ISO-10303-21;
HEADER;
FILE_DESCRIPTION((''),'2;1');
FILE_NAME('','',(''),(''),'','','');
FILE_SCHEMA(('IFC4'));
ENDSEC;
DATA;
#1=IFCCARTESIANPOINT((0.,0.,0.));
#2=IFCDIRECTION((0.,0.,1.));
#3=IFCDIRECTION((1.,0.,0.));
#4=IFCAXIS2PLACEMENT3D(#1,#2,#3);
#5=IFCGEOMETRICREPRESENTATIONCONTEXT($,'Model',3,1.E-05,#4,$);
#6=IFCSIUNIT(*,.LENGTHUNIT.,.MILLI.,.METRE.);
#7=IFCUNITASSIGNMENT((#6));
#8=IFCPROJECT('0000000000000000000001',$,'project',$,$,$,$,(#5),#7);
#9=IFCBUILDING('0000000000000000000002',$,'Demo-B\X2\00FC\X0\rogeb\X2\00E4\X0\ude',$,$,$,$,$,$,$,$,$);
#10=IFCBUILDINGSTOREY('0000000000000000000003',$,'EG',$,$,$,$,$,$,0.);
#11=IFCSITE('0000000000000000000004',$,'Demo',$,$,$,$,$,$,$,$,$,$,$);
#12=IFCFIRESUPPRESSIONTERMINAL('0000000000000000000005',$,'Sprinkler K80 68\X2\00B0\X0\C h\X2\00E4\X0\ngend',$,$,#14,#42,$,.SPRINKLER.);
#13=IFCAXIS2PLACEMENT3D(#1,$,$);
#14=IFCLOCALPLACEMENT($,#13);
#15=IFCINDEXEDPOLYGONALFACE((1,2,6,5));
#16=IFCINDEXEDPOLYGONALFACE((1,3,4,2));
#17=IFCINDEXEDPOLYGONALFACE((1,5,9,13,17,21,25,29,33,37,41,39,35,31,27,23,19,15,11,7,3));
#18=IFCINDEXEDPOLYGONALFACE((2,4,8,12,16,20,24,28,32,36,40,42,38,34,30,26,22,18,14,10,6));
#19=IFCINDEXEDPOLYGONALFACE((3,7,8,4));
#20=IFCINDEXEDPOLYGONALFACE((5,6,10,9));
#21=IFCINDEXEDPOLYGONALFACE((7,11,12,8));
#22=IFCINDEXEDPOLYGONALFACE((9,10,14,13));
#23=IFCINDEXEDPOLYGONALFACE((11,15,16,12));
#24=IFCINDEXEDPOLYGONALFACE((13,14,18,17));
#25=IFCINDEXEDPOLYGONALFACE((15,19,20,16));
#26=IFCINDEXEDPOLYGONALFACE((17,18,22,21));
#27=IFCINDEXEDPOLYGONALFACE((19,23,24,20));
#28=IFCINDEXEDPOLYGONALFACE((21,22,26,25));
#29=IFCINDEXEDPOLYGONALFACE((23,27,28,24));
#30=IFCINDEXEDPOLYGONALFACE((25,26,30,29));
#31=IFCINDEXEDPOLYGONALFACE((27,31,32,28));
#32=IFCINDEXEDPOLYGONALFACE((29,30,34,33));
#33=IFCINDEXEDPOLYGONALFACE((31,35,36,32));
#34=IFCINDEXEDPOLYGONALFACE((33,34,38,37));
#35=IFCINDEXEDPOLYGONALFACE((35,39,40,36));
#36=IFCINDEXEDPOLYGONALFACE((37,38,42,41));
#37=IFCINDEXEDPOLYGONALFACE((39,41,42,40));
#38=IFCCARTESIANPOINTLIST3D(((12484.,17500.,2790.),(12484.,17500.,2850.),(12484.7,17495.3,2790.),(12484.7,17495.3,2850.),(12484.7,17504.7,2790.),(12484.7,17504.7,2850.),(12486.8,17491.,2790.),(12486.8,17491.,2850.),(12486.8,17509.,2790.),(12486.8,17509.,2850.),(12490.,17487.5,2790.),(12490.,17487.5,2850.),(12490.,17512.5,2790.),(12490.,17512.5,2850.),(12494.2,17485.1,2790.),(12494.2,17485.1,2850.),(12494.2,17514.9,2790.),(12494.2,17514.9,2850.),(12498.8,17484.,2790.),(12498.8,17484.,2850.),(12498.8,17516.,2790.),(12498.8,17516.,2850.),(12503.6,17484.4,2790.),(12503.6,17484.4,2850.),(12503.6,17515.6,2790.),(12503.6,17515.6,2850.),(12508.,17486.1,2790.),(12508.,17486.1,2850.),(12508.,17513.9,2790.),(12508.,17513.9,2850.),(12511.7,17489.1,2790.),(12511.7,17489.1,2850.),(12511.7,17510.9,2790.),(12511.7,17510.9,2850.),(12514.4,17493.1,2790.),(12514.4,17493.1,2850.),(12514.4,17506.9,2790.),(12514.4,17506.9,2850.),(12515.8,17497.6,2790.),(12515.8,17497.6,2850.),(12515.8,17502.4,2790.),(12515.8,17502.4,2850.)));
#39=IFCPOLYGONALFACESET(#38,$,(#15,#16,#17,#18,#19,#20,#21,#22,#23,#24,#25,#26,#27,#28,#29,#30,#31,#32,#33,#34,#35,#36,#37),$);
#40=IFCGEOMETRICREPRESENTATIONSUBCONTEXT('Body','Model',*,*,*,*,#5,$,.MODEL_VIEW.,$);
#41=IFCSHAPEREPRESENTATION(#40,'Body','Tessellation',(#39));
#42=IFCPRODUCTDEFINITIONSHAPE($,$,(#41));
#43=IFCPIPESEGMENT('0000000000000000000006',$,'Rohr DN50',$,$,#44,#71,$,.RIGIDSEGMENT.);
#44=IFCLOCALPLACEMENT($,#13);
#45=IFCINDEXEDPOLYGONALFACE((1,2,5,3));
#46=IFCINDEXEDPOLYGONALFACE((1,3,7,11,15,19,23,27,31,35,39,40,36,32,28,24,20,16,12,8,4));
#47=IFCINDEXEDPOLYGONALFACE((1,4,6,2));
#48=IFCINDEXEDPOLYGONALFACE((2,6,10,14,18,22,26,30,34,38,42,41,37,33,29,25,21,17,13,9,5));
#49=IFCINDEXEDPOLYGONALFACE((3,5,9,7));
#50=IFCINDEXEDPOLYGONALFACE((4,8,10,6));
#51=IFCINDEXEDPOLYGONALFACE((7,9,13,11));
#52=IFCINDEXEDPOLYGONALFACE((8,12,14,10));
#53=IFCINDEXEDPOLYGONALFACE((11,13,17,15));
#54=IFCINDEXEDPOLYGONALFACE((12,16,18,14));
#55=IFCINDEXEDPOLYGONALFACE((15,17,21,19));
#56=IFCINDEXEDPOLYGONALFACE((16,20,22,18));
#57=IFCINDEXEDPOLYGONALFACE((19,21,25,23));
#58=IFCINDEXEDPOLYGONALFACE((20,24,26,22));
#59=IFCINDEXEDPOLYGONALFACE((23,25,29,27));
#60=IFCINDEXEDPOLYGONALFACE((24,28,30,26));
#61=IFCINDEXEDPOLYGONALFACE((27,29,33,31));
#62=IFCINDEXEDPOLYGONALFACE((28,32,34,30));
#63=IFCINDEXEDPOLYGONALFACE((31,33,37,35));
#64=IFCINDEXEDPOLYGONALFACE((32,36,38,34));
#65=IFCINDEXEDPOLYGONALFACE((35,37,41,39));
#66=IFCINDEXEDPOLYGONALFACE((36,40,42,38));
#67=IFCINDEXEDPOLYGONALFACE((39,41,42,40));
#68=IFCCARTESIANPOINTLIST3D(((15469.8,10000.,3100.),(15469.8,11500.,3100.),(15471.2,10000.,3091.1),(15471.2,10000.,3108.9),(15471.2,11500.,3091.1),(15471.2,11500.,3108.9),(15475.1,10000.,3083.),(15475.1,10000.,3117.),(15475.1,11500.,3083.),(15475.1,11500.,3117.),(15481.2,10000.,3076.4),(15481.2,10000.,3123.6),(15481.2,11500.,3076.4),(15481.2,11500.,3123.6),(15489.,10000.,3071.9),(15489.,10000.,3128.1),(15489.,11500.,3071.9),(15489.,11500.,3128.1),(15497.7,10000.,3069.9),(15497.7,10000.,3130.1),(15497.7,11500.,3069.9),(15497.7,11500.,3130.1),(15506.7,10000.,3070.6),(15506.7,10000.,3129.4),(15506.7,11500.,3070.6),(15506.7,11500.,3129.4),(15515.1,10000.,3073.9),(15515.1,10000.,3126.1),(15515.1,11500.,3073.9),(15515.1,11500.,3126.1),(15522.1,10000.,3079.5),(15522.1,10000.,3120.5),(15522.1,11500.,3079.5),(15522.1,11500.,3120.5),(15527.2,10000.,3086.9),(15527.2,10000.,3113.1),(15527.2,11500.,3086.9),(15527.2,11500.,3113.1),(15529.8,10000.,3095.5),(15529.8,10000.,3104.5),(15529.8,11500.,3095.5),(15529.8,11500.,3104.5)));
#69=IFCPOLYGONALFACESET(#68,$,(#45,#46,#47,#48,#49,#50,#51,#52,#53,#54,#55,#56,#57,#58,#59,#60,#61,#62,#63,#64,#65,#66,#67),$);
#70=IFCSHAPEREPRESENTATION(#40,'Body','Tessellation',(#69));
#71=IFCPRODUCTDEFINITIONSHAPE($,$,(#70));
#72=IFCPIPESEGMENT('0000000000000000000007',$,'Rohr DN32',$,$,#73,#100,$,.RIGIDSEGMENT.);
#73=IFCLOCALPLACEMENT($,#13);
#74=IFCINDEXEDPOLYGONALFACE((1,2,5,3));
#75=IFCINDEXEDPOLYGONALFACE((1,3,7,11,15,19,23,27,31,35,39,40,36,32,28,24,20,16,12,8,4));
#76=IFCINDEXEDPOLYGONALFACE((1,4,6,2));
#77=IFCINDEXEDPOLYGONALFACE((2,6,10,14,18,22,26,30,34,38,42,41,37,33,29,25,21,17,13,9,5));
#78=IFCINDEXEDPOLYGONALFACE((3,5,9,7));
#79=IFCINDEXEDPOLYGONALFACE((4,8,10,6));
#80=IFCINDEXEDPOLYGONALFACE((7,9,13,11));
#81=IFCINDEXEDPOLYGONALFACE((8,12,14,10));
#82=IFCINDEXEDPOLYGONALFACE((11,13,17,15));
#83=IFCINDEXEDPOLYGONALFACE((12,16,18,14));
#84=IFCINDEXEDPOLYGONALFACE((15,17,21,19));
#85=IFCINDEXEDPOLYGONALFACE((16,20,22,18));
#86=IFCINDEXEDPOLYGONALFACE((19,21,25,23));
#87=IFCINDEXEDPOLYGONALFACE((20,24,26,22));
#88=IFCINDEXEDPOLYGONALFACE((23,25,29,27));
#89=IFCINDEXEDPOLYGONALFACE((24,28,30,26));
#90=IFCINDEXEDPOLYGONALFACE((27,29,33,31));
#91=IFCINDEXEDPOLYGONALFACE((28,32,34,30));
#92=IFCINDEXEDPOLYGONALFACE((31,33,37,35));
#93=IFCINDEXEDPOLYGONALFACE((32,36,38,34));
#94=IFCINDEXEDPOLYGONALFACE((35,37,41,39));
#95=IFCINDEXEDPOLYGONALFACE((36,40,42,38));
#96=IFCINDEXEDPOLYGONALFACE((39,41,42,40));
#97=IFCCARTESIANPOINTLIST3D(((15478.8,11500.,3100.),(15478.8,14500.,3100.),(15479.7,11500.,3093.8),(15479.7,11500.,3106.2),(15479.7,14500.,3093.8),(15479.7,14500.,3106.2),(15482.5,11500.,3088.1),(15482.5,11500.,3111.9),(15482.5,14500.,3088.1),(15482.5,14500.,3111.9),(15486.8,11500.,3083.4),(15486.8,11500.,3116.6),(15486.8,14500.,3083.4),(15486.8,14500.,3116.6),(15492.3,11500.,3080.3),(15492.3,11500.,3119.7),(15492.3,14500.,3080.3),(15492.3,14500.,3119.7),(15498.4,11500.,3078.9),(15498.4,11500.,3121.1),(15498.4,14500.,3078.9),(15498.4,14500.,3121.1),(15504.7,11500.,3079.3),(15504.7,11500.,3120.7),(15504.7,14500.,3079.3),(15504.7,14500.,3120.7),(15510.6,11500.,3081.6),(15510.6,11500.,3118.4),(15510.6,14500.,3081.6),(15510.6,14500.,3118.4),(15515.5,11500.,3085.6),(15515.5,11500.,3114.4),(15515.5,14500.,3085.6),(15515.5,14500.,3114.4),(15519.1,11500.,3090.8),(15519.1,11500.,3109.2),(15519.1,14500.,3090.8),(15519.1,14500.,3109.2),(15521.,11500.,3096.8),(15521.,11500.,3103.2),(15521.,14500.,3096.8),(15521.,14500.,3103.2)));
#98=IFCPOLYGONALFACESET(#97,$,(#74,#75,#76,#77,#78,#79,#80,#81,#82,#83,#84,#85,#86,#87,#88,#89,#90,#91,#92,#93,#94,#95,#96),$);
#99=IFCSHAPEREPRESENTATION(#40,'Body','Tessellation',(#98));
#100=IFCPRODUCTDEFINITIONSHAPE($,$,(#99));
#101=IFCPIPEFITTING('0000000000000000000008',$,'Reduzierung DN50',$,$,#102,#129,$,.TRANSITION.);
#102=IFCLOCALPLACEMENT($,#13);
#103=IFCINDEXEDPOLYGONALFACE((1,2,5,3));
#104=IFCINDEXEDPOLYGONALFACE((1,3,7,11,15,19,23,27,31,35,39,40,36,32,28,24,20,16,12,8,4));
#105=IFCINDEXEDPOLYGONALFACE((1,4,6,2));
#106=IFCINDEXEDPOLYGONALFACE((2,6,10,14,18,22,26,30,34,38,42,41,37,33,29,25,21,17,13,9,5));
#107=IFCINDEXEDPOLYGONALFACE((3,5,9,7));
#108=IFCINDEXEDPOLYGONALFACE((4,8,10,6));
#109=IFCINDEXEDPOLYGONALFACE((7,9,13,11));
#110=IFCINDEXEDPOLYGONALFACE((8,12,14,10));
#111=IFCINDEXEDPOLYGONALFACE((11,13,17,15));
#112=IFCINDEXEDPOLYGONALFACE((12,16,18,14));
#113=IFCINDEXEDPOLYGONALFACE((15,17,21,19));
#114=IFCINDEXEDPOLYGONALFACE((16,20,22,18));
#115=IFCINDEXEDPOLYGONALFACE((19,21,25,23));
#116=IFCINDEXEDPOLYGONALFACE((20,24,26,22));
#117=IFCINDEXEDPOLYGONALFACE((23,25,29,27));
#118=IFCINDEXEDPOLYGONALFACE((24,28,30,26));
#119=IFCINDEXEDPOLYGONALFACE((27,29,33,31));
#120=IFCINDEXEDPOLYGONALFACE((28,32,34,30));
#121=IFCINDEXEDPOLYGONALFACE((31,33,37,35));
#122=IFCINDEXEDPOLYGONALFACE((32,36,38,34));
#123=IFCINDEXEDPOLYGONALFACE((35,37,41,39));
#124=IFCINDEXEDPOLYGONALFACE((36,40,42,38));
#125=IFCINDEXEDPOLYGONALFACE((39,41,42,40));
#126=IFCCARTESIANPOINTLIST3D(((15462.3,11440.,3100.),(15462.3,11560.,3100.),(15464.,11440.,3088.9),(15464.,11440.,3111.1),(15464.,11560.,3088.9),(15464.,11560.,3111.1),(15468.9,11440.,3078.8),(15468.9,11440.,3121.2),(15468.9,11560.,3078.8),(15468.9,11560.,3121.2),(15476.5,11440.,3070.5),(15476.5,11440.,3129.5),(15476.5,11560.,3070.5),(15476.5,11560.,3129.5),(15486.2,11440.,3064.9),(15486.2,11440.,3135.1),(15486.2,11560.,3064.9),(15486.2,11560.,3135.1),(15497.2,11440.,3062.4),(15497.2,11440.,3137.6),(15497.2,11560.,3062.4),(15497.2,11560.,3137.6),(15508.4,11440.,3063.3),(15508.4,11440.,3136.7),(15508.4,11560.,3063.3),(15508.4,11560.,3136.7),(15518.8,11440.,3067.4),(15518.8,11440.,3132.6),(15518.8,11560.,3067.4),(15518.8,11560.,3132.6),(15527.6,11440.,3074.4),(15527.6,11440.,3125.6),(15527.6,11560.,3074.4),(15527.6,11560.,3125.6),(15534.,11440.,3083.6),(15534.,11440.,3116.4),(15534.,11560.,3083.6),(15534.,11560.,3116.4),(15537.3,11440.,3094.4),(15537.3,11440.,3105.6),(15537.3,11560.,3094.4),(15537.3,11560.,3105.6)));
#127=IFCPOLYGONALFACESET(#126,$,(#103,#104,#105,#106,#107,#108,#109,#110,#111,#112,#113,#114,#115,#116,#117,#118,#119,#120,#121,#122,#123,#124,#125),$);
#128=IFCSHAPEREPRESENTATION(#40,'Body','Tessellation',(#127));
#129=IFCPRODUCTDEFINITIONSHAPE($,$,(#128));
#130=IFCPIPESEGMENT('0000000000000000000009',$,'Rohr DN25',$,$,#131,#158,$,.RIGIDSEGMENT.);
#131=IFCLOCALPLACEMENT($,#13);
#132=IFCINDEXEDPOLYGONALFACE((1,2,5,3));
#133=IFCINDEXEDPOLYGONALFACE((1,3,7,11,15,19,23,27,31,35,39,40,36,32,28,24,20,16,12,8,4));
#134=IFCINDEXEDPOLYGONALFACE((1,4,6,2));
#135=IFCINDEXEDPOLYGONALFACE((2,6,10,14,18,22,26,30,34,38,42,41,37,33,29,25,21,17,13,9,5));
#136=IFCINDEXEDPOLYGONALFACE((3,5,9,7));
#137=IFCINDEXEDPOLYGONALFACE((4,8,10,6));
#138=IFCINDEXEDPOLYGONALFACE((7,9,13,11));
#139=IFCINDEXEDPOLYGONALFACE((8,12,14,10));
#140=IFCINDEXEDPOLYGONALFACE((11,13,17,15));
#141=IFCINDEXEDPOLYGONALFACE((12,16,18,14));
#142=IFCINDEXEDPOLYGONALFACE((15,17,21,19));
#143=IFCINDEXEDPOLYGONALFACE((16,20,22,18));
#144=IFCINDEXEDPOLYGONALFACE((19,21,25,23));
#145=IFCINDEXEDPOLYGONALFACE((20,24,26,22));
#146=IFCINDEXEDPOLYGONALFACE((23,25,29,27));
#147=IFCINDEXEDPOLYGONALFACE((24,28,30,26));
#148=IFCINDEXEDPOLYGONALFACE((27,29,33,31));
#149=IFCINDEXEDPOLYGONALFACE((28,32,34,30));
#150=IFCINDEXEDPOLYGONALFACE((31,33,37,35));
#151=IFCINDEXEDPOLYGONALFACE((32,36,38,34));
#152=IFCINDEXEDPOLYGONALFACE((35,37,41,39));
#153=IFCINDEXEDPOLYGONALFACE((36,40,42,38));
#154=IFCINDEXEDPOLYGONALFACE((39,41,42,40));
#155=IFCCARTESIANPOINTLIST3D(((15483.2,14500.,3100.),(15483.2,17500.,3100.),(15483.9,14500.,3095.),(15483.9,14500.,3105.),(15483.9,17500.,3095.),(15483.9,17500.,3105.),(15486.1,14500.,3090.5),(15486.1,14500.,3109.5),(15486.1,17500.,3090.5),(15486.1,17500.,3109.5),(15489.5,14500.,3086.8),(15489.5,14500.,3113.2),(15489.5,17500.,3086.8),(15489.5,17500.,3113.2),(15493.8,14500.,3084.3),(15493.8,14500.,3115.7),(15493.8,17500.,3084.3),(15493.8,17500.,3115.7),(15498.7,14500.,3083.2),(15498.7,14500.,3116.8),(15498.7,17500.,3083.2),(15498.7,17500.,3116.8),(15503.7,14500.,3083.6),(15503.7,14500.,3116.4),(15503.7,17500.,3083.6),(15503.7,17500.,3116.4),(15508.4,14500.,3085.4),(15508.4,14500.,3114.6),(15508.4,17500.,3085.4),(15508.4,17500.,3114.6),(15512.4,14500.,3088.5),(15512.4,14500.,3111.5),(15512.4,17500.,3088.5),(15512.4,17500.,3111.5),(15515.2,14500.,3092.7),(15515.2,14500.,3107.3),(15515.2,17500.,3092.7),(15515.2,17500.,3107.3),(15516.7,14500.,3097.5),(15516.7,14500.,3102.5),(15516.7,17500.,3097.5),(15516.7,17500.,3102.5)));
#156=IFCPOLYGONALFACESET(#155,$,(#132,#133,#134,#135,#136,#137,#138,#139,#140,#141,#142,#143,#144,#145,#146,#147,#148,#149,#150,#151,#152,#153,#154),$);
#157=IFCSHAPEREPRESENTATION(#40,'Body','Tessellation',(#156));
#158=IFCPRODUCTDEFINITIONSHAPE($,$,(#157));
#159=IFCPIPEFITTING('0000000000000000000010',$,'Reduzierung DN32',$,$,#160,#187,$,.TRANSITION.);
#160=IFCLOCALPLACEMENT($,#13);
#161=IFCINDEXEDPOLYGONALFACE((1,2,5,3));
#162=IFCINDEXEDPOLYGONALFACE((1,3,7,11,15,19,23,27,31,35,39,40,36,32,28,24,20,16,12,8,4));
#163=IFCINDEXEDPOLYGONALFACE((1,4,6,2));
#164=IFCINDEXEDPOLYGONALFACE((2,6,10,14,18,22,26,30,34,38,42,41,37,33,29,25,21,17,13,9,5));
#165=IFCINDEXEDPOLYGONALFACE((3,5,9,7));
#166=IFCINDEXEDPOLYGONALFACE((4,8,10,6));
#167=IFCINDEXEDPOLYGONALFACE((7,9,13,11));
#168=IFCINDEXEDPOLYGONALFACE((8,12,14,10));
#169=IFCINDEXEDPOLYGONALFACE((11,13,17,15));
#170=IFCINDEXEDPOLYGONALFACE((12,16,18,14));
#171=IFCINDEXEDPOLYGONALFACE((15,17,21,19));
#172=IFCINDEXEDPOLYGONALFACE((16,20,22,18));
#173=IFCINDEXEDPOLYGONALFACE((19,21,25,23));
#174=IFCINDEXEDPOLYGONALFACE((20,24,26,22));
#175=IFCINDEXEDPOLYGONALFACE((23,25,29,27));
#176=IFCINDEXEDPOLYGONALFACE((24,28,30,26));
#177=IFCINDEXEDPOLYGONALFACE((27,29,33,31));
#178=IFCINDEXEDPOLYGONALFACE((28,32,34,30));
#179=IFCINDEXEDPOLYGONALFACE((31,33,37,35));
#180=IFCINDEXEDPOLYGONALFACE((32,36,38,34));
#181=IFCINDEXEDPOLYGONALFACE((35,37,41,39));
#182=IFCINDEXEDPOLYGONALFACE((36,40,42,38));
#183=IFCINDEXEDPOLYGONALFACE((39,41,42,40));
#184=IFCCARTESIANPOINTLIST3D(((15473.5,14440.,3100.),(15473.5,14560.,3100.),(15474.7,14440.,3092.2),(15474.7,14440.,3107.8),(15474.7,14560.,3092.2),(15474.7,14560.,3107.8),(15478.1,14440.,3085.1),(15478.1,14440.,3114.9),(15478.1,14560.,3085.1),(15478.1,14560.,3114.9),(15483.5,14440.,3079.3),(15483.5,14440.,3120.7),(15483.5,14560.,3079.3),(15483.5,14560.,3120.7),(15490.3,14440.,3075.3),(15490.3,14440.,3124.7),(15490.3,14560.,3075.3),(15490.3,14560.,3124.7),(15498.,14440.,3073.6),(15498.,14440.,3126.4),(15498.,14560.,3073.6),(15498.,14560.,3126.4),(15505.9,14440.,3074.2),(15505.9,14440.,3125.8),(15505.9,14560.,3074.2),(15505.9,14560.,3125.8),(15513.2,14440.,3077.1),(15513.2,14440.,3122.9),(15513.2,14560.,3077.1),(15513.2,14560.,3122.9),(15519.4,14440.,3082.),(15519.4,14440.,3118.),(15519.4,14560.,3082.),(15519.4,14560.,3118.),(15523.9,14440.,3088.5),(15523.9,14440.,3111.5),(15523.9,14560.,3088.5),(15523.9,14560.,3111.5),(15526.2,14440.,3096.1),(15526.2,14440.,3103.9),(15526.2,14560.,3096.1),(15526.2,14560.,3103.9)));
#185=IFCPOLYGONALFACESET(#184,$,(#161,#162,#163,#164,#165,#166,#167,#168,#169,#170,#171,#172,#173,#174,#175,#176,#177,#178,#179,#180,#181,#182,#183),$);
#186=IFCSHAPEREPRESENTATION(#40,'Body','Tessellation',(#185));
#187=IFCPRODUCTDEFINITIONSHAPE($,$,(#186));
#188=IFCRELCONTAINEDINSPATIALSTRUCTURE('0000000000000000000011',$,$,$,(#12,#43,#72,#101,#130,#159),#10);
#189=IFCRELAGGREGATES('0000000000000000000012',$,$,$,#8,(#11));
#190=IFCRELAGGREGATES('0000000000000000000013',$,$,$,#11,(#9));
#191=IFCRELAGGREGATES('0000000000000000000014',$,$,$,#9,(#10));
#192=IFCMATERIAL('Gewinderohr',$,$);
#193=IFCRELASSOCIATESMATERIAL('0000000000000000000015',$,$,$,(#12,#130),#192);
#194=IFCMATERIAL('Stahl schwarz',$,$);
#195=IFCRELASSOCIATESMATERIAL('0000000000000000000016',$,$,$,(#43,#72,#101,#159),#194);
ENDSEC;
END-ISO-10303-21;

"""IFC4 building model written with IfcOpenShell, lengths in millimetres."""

from ifc_helpers import new_model, si_unit, frame, origin_with_axes, place, context, subcontext, project, spatial, circle, extrude, material, element, save


model = new_model("IFC4")

# Units and contexts
model_context = context("Model", 3, precision=1e-05, world=origin_with_axes())
body_context = subcontext(model_context, "Body", "Model", "MODEL_VIEW")
ifc_project = project(units=[si_unit("LENGTHUNIT", "METRE", prefix="MILLI")], contexts=[model_context])

# Site, building, storey
site = spatial("IfcSite", under=ifc_project, Name="Demo")
building = spatial("IfcBuilding", under=site, Name="Demo-Bürogebäude")
storey = spatial("IfcBuildingStorey", under=building, Name="EG", Elevation=0.0)

# Shared definitions
ifc_material_1 = material(Name="Stahl schwarz")

# Shared definitions
ifc_material_2 = material(Name="Gewinderohr")

# Fire suppression terminal
fire_suppression_terminal_1_placement = place(None, frame((12500.0, 17500.0, 2850.0), z_axis=(0.0, 0.0, -1.0), x_axis=(-1.0, 0.0, 0.0)))
element("IfcFireSuppressionTerminal", 1, at=fire_suppression_terminal_1_placement, inside=storey, material=ifc_material_2, Name="Sprinkler K80 68°C hängend", PredefinedType="SPRINKLER", context=body_context, shape_type="SweptSolid", body=[
    extrude(circle(Radius=16.0), origin_with_axes(), (0.0, 0.0, 1.0), 60.0),
])

# Pipe segments
pipe_segment_1_placement = place(None, frame((15500.0, 10000.0, 3100.0), z_axis=(0.0, 1.0, 0.0), x_axis=(-1.0, 0.0, 0.0)))
element("IfcPipeSegment", 2, at=pipe_segment_1_placement, inside=storey, material=ifc_material_1, Name="Rohr DN50", PredefinedType="RIGIDSEGMENT", context=body_context, shape_type="SweptSolid", body=[
    extrude(circle(Radius=30.1), origin_with_axes(), (0.0, 0.0, 1.0), 1500.0),
])
pipe_segment_2_placement = place(None, frame((15500.0, 11500.0, 3100.0), z_axis=(0.0, 1.0, 0.0), x_axis=(-1.0, 0.0, 0.0)))
element("IfcPipeSegment", 3, at=pipe_segment_2_placement, inside=storey, material=ifc_material_1, Name="Rohr DN32", PredefinedType="RIGIDSEGMENT", context=body_context, shape_type="SweptSolid", body=[
    extrude(circle(Radius=21.2), origin_with_axes(), (0.0, 0.0, 1.0), 3000.0),
])

# Pipe fitting
pipe_fitting_1_placement = place(None, frame((15500.0, 11440.0, 3100.0), z_axis=(0.0, 1.0, 0.0), x_axis=(-1.0, 0.0, 0.0)))
element("IfcPipeFitting", 4, at=pipe_fitting_1_placement, inside=storey, material=ifc_material_1, Name="Reduzierung DN50", PredefinedType="TRANSITION", context=body_context, shape_type="SweptSolid", body=[
    extrude(circle(Radius=37.7), origin_with_axes(), (0.0, 0.0, 1.0), 120.0),
])

# Pipe segment
pipe_segment_3_placement = place(None, frame((15500.0, 14500.0, 3100.0), z_axis=(0.0, 1.0, 0.0), x_axis=(-1.0, 0.0, 0.0)))
element("IfcPipeSegment", 5, at=pipe_segment_3_placement, inside=storey, material=ifc_material_2, Name="Rohr DN25", PredefinedType="RIGIDSEGMENT", context=body_context, shape_type="SweptSolid", body=[
    extrude(circle(Radius=16.9), origin_with_axes(), (0.0, 0.0, 1.0), 3000.0),
])

# Pipe fitting
pipe_fitting_2_placement = place(None, frame((15500.0, 14440.0, 3100.0), z_axis=(0.0, 1.0, 0.0), x_axis=(-1.0, 0.0, 0.0)))
element("IfcPipeFitting", 6, at=pipe_fitting_2_placement, inside=storey, material=ifc_material_1, Name="Reduzierung DN32", PredefinedType="TRANSITION", context=body_context, shape_type="SweptSolid", body=[
    extrude(circle(Radius=26.5), origin_with_axes(), (0.0, 0.0, 1.0), 120.0),
])

save(model, "model.ifc")
